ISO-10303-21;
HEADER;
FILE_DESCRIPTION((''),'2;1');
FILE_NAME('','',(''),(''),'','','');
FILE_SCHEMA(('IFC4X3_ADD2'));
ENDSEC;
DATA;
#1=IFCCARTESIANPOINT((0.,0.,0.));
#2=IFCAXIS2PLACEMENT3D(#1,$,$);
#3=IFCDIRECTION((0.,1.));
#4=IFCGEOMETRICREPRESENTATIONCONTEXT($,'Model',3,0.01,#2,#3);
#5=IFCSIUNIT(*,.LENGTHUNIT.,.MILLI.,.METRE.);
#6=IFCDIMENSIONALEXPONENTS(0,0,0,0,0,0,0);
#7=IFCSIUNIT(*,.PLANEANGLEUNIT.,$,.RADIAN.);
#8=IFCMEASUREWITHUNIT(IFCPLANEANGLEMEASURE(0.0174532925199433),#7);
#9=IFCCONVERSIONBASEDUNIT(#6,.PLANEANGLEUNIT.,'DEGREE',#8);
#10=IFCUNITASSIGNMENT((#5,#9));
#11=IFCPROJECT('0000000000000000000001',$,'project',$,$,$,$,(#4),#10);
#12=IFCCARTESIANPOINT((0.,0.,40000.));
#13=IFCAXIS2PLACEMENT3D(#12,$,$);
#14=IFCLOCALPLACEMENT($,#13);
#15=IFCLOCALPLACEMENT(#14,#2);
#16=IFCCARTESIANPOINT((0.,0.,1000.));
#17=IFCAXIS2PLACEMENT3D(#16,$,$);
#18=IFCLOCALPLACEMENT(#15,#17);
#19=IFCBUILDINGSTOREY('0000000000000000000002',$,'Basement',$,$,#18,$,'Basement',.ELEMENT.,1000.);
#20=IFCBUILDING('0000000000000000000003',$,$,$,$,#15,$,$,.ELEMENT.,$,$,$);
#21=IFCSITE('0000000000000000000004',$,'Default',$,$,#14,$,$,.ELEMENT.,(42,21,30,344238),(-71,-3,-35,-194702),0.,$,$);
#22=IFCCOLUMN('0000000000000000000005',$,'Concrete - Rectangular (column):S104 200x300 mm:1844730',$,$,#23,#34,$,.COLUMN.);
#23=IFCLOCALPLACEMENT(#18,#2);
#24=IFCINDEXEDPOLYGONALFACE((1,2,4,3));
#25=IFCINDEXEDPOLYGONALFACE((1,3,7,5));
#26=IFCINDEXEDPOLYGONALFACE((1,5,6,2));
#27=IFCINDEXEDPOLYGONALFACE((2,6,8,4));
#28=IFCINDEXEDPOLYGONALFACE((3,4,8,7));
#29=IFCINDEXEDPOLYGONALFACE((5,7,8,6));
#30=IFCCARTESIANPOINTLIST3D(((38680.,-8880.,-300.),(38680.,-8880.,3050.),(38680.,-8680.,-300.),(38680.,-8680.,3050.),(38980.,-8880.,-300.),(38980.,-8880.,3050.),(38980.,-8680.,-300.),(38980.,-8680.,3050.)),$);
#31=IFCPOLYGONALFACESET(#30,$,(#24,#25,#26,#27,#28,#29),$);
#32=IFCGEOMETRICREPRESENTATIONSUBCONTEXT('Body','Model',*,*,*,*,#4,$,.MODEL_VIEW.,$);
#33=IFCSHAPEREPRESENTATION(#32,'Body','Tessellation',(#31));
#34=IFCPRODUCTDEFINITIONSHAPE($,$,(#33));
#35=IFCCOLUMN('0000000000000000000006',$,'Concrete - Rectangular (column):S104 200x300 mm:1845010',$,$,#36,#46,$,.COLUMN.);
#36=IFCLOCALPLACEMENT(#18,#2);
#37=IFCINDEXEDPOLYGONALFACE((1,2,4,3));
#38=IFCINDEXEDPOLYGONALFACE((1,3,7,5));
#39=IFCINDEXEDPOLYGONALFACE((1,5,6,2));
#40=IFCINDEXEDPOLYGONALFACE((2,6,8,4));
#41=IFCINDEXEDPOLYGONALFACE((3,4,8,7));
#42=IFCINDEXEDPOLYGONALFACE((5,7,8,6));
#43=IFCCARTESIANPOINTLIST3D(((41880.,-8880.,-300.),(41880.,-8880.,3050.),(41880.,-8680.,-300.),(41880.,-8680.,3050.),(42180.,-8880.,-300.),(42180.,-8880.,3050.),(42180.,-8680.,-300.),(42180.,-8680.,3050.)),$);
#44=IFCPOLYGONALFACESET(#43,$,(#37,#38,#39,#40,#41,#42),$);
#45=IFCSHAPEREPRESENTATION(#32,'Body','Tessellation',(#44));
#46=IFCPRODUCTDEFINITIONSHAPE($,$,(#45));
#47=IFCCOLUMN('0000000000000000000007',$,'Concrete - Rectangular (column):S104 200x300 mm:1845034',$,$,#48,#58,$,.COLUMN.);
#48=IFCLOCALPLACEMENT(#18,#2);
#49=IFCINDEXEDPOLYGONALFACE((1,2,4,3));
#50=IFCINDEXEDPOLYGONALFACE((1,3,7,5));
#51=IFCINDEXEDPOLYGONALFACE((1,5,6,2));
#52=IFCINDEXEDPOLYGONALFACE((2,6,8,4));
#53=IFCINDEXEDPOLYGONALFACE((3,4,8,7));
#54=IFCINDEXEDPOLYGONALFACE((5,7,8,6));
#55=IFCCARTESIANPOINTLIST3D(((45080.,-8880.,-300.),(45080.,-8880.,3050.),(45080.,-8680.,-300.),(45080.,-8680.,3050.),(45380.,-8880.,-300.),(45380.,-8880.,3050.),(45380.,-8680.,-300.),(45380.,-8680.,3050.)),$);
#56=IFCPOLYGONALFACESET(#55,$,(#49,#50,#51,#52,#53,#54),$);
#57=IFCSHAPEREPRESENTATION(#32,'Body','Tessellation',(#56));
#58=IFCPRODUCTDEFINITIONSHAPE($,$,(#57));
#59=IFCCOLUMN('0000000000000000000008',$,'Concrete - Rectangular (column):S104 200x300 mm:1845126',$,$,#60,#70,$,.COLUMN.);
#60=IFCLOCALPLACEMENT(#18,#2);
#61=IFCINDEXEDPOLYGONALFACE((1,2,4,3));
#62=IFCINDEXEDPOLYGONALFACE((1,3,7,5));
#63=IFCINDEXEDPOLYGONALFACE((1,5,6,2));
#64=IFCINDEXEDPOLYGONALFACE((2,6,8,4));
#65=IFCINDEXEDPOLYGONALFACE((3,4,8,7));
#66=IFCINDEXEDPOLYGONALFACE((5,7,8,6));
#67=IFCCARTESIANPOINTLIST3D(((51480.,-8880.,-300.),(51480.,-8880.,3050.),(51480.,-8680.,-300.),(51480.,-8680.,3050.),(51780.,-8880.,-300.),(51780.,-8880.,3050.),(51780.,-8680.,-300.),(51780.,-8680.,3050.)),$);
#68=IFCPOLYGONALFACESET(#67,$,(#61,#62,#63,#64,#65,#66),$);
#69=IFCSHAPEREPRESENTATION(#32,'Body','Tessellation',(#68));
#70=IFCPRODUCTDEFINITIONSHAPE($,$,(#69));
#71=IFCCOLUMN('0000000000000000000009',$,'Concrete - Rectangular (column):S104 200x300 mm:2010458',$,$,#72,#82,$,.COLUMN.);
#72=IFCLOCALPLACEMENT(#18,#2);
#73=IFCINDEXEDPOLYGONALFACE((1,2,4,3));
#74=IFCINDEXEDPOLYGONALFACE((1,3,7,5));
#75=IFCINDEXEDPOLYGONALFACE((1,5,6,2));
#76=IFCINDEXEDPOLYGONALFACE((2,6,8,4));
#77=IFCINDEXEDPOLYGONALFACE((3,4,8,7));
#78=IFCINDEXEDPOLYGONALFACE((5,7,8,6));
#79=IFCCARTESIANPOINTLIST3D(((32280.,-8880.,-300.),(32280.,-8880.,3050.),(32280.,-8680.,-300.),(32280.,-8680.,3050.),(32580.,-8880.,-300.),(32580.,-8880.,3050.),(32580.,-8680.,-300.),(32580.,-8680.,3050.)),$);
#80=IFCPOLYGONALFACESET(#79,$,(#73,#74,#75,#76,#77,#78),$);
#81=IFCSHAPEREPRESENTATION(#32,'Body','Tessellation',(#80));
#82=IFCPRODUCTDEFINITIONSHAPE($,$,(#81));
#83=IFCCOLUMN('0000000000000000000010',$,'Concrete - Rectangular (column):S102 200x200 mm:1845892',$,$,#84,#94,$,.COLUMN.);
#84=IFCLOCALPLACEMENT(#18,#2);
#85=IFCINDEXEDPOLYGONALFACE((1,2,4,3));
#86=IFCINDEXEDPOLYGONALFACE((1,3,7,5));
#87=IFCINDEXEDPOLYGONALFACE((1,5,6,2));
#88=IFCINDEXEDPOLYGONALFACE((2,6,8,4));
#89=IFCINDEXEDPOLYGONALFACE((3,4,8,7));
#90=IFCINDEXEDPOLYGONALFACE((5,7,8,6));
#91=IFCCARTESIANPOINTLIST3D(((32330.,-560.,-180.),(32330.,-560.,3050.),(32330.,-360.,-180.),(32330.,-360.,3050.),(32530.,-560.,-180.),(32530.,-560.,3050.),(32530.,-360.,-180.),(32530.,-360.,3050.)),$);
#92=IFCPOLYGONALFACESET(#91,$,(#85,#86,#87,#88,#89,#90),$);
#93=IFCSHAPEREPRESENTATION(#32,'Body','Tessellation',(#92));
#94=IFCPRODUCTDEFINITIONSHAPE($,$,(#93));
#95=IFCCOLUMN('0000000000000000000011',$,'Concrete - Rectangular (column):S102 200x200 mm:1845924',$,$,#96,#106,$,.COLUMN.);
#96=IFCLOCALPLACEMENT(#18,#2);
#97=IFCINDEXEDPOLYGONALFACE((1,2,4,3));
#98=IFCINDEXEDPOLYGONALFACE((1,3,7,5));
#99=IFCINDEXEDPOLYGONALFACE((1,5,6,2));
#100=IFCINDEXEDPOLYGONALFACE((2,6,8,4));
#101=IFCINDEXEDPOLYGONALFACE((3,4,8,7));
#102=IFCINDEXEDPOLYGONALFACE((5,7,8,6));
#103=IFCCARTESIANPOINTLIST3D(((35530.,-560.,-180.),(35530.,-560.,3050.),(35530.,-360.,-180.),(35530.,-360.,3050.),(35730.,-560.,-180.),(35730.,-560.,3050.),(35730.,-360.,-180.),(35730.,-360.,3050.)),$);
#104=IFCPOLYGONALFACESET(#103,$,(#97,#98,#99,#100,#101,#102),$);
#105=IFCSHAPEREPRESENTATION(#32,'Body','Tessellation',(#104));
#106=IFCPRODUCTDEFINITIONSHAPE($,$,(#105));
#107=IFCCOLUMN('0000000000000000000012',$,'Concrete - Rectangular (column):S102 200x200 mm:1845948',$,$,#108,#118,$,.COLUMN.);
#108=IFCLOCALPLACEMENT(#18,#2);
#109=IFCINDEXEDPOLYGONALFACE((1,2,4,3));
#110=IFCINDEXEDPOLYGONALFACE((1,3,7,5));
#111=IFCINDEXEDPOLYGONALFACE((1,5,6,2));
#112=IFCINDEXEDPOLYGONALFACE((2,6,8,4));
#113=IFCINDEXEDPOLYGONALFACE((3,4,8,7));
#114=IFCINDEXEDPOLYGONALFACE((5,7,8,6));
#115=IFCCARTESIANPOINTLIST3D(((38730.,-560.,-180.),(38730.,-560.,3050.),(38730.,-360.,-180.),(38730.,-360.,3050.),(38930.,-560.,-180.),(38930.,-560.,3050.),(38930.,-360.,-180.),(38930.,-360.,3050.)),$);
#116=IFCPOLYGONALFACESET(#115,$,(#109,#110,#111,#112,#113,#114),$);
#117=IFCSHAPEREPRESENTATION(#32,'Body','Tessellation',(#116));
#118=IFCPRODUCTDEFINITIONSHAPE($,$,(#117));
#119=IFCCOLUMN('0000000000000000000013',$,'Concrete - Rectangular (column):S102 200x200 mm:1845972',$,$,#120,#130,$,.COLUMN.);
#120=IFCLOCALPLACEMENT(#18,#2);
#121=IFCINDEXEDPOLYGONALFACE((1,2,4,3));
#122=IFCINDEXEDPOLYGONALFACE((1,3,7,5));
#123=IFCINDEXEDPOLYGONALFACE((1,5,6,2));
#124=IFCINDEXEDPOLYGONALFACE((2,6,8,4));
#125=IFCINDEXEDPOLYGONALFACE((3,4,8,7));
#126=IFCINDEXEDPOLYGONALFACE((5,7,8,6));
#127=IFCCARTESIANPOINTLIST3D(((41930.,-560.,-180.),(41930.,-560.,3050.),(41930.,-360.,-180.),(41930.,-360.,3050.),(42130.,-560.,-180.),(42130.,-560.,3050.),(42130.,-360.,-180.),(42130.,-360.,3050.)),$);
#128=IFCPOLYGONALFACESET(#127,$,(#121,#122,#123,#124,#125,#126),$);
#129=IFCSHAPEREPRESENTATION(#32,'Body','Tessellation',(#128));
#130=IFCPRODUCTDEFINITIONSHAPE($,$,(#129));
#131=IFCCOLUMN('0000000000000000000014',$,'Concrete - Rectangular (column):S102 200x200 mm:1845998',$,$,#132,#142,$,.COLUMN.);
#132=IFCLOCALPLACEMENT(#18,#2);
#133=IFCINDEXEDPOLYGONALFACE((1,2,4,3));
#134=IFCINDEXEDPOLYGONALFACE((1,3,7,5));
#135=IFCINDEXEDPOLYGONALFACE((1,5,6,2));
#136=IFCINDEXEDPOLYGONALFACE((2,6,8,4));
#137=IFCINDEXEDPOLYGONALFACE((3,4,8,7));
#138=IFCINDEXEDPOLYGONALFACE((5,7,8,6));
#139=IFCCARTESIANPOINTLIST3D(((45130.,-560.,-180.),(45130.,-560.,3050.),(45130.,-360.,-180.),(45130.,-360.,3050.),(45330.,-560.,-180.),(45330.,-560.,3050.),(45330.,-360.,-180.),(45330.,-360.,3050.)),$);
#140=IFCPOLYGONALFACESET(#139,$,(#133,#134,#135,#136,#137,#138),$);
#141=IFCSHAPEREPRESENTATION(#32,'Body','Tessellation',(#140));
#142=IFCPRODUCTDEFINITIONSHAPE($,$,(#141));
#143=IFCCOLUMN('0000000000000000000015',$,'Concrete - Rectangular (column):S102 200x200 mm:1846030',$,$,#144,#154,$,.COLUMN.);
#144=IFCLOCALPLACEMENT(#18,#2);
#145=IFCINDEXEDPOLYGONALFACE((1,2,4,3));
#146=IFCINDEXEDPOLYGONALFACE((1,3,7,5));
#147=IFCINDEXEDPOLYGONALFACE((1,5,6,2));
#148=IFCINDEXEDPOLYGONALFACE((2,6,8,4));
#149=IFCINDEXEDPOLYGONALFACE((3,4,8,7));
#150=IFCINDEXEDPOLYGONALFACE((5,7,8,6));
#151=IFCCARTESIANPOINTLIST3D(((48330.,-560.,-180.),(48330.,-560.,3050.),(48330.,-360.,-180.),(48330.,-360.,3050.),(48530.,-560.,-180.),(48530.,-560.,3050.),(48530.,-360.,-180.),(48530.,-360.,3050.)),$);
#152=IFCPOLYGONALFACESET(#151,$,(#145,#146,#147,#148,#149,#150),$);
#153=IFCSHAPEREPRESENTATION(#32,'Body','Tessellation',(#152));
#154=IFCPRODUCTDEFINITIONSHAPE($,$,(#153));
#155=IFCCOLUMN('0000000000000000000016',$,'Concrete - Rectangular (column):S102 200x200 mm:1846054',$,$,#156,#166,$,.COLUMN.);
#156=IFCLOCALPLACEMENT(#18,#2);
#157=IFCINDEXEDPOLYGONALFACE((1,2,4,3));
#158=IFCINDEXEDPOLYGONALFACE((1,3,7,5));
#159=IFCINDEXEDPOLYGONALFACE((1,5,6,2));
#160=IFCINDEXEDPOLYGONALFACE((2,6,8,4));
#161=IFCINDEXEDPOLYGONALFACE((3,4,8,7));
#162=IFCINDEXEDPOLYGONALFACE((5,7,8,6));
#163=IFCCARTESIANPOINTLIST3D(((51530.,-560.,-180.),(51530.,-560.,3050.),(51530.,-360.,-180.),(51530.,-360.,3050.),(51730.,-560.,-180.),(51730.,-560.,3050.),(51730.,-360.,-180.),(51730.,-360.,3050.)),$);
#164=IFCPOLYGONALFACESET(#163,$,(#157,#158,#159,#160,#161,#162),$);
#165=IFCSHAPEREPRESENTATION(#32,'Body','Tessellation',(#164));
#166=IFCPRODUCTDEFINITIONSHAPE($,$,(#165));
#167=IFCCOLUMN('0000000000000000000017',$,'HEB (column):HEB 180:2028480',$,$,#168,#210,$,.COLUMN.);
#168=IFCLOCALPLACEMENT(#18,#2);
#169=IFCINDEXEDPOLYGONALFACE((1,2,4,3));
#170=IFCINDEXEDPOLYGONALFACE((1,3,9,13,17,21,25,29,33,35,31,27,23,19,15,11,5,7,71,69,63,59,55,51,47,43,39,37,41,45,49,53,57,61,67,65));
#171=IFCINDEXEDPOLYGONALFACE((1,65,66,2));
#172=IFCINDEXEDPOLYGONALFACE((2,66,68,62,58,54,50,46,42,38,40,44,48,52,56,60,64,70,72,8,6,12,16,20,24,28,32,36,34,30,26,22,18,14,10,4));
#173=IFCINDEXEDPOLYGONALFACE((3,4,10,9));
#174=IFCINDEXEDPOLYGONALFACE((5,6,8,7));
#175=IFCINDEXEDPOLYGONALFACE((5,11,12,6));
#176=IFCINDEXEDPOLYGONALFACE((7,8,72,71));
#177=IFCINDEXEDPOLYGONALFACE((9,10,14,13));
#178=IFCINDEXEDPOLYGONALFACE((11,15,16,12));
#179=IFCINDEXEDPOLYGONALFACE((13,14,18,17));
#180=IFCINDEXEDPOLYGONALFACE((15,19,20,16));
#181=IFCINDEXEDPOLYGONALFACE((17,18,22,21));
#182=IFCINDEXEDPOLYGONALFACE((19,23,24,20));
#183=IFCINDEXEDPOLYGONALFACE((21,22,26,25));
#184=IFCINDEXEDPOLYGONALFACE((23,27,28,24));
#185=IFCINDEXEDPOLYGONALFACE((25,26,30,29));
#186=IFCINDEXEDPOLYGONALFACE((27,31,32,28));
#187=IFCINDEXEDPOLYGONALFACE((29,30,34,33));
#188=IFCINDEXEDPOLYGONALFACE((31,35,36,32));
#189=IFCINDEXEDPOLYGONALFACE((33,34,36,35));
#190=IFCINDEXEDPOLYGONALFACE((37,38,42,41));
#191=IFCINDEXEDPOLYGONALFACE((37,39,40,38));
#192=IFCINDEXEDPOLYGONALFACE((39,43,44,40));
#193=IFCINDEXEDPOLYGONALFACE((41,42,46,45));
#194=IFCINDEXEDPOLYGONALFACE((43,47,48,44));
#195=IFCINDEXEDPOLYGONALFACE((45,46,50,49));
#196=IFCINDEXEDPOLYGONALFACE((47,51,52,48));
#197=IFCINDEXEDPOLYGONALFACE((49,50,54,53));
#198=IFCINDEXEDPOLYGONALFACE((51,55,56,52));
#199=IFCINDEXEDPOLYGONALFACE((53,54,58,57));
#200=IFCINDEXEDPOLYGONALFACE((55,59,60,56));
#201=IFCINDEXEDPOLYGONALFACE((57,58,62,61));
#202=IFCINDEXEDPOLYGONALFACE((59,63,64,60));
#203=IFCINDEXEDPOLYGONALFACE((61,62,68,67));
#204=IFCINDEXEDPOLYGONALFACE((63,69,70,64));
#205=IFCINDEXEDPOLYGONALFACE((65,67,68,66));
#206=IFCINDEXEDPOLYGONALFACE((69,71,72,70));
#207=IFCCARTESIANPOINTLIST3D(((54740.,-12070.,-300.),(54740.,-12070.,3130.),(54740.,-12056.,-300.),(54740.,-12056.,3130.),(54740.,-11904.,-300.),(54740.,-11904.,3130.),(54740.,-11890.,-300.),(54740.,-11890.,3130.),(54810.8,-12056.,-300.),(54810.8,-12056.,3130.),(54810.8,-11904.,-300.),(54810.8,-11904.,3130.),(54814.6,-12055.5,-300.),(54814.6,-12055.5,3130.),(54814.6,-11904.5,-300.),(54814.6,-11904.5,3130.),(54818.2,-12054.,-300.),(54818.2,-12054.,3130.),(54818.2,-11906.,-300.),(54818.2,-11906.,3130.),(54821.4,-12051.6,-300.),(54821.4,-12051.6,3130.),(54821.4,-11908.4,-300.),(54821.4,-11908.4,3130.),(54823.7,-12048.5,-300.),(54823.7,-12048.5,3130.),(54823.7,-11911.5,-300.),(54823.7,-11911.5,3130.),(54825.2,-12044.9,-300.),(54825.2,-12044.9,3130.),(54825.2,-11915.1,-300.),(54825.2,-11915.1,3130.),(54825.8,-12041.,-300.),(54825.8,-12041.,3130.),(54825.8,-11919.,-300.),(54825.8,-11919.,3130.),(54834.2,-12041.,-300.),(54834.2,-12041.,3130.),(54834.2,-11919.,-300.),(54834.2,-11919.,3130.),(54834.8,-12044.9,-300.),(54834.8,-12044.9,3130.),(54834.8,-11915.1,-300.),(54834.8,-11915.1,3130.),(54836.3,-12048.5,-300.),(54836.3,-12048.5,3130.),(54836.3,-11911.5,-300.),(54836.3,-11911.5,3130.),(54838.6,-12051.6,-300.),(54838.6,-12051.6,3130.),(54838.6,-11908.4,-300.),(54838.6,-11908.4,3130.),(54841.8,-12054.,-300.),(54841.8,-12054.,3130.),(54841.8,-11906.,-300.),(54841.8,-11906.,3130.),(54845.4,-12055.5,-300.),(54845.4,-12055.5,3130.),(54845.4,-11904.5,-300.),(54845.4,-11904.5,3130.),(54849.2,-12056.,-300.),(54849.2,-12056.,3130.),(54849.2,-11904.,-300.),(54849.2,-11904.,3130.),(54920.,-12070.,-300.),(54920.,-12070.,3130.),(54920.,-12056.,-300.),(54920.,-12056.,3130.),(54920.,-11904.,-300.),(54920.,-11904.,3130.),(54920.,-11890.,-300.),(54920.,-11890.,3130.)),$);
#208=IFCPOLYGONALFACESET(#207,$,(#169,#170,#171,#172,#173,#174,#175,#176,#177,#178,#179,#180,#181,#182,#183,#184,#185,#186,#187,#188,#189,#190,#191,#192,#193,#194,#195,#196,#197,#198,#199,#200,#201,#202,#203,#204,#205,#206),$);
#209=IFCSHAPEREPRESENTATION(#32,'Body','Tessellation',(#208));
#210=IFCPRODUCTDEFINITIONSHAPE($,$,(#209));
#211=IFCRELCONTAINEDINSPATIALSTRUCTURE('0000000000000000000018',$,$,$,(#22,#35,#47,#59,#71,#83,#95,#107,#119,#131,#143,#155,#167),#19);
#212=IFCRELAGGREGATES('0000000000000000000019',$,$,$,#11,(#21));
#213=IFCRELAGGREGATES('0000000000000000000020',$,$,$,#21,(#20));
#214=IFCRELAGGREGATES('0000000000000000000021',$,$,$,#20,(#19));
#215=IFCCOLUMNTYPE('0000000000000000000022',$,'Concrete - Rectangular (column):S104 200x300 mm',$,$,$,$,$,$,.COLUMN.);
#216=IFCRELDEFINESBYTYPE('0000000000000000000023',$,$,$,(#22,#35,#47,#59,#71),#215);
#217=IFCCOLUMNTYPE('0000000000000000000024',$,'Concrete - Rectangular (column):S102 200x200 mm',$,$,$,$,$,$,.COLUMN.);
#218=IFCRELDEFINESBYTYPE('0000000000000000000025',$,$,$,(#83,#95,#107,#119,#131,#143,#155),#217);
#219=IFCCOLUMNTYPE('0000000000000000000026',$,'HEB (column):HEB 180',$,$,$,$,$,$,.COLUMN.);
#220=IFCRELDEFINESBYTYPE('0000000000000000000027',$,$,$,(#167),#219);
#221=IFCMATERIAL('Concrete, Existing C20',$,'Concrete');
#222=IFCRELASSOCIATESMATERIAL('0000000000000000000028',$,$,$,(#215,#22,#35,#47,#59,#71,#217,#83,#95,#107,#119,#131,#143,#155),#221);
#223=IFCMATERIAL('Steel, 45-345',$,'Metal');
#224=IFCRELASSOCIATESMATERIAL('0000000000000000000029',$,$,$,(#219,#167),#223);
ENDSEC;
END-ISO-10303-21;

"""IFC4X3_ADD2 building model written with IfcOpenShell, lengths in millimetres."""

from ifc_helpers import new_model, entity, si_unit, converted_unit, direction, frame, frame_2d, origin, origin_2d_with_axis, place, context, subcontext, project, spatial, rectangle, i_section, extrude, source, transform, mapped, material, material_profile, profile_set, profile_usage, type_object, type_shapes, element, save


model = new_model("IFC4X3_ADD2")

# Units and contexts
model_context = context("Model", 3, precision=0.01, world=origin(), true_north=direction((0.0, 1.0)))
body_context = subcontext(model_context, "Body", "Model", "MODEL_VIEW")
ifc_project = project(units=[si_unit("LENGTHUNIT", "METRE", prefix="MILLI"), converted_unit("PLANEANGLEUNIT", "DEGREE", entity("IfcPlaneAngleMeasure", 0.0174532925199433), si_unit("PLANEANGLEUNIT", "RADIAN"), dimensions=[0, 0, 0, 0, 0, 0, 0])], contexts=[model_context])

# Site, building, storey
site_placement = place(None, frame((0.0, 0.0, 40000.0)))
site = spatial("IfcSite", under=ifc_project, at=site_placement, Name="Default", CompositionType="ELEMENT", RefLatitude=(42, 21, 30, 344238), RefLongitude=(-71, -3, -35, -194702), RefElevation=0.0)
building_placement = place(site_placement, origin())
building = spatial("IfcBuilding", under=site, at=building_placement, CompositionType="ELEMENT")
storey_placement = place(building_placement, frame((0.0, 0.0, 1000.0)))
storey = spatial("IfcBuildingStorey", under=building, at=storey_placement, Name="Basement", LongName="Basement", CompositionType="ELEMENT", Elevation=1000.0)

# Columns
ifc_material_1 = material(Name="Concrete, Existing C20", Category="Concrete")
ifc_material_profile_1 = material_profile(ifc_material_1, rectangle(XDim=200.0, YDim=300.0, at=frame_2d((0.0, 0.0), x_axis=(1.0, 0.0))), Name="S104 200x300 mm")
ifc_profile_set_1 = profile_set([ifc_material_profile_1], Name="S104 200x300 mm")
ifc_profile_usage_1 = profile_usage(ifc_profile_set_1)
column_type_1 = type_object("IfcColumnType", Name="Concrete - Rectangular (column):S104 200x300 mm", PredefinedType="COLUMN", material=ifc_profile_set_1)
shared_shape_1 = source(origin(), body_context, "Body", "SweptSolid", [
    extrude(rectangle(XDim=200.0, YDim=300.0, at=origin_2d_with_axis()), frame((0.0, 0.0, 700.0), z_axis=(0.0, 0.0, 1.0), x_axis=(-1.0, 0.0, 0.0)), (0.0, 0.0, 1.0), 3350.0),
])
type_shapes(column_type_1, [shared_shape_1])
for number, where, z_axis, x_axis, name in (
    (1, (38830.0, -8780.0, -1000.0), (0.0, 0.0, 1.0), (0.0, -1.0, 0.0), "Concrete - Rectangular (column):S104 200x300 mm:1844730"),
    (2, (42030.0, -8780.0, -1000.0), (0.0, 0.0, 1.0), (0.0, -1.0, 0.0), "Concrete - Rectangular (column):S104 200x300 mm:1845010"),
    (3, (45230.0, -8780.0, -1000.0), (0.0, 0.0, 1.0), (0.0, -1.0, 0.0), "Concrete - Rectangular (column):S104 200x300 mm:1845034"),
    (4, (51630.0, -8780.0, -1000.0), (0.0, 0.0, 1.0), (0.0, -1.0, 0.0), "Concrete - Rectangular (column):S104 200x300 mm:1845126"),
    (5, (32430.0, -8780.0, -1000.0), (0.0, 0.0, 1.0), (0.0, -1.0, 0.0), "Concrete - Rectangular (column):S104 200x300 mm:2010458"),
):
    element("IfcColumn", number, at=place(storey_placement, frame(where, z_axis=z_axis, x_axis=x_axis)), inside=storey, type_object=column_type_1, material=ifc_profile_usage_1, Name=name, PredefinedType="COLUMN", context=body_context, shape_type="MappedRepresentation", body=[
        mapped(shared_shape_1, transform((0.0, 0.0, 0.0), scale=1.0)),
    ])
ifc_material_profile_2 = material_profile(ifc_material_1, rectangle(XDim=200.0, YDim=200.0, at=frame_2d((0.0, 0.0), x_axis=(1.0, 0.0))), Name="S102 200x200 mm")
ifc_profile_set_2 = profile_set([ifc_material_profile_2], Name="S102 200x200 mm")
ifc_profile_usage_2 = profile_usage(ifc_profile_set_2)
column_type_2 = type_object("IfcColumnType", Name="Concrete - Rectangular (column):S102 200x200 mm", PredefinedType="COLUMN", material=ifc_profile_set_2)
shared_shape_2 = source(origin(), body_context, "Body", "SweptSolid", [
    extrude(rectangle(XDim=200.0, YDim=200.0, at=origin_2d_with_axis()), frame((0.0, 0.0, 820.0), z_axis=(0.0, 0.0, 1.0), x_axis=(-1.0, 0.0, 0.0)), (0.0, 0.0, 1.0), 3230.0),
])
type_shapes(column_type_2, [shared_shape_2])
for number, where, z_axis, x_axis, name in (
    (6, (32430.0, -460.0, -1000.0), (0.0, 0.0, 1.0), (0.0, -1.0, 0.0), "Concrete - Rectangular (column):S102 200x200 mm:1845892"),
    (7, (35630.0, -460.0, -1000.0), (0.0, 0.0, 1.0), (0.0, -1.0, 0.0), "Concrete - Rectangular (column):S102 200x200 mm:1845924"),
    (8, (38830.0, -460.0, -1000.0), (0.0, 0.0, 1.0), (0.0, -1.0, 0.0), "Concrete - Rectangular (column):S102 200x200 mm:1845948"),
    (9, (42030.0, -460.0, -1000.0), (0.0, 0.0, 1.0), (0.0, -1.0, 0.0), "Concrete - Rectangular (column):S102 200x200 mm:1845972"),
    (10, (45230.0, -460.0, -1000.0), (0.0, 0.0, 1.0), (0.0, -1.0, 0.0), "Concrete - Rectangular (column):S102 200x200 mm:1845998"),
    (11, (48430.0, -460.0, -1000.0), (0.0, 0.0, 1.0), (0.0, -1.0, 0.0), "Concrete - Rectangular (column):S102 200x200 mm:1846030"),
    (12, (51630.0, -460.0, -1000.0), (0.0, 0.0, 1.0), (0.0, -1.0, 0.0), "Concrete - Rectangular (column):S102 200x200 mm:1846054"),
):
    element("IfcColumn", number, at=place(storey_placement, frame(where, z_axis=z_axis, x_axis=x_axis)), inside=storey, type_object=column_type_2, material=ifc_profile_usage_2, Name=name, PredefinedType="COLUMN", context=body_context, shape_type="MappedRepresentation", body=[
        mapped(shared_shape_2, transform((0.0, 0.0, 0.0), scale=1.0)),
    ])
ifc_material_2 = material(Name="Steel, 45-345", Category="Metal")
ifc_material_profile_3 = material_profile(ifc_material_2, i_section(OverallWidth=180.0, OverallDepth=180.0, WebThickness=8.5, FlangeThickness=14.0, FilletRadius=15.0, at=origin_2d_with_axis()), Name="HEB 180")
ifc_profile_set_3 = profile_set([ifc_material_profile_3], Name="HEB 180")
ifc_profile_usage_3 = profile_usage(ifc_profile_set_3)
column_type_3 = type_object("IfcColumnType", Name="HEB (column):HEB 180", PredefinedType="COLUMN", material=ifc_profile_set_3)
shared_shape_3 = source(origin(), body_context, "Body", "SweptSolid", [
    extrude(i_section(OverallWidth=180.0, OverallDepth=180.0, WebThickness=8.5, FlangeThickness=14.0, FilletRadius=15.0, at=origin_2d_with_axis()), frame((0.0, 0.0, 700.0), z_axis=(0.0, 0.0, 1.0), x_axis=(-1.0, 0.0, 0.0)), (0.0, 0.0, 1.0), 3430.0),
])
type_shapes(column_type_3, [shared_shape_3])
column_placement = place(storey_placement, frame((54830.0, -11980.0, -1000.0)))
element("IfcColumn", 13, at=column_placement, inside=storey, type_object=column_type_3, material=ifc_profile_usage_3, Name="HEB (column):HEB 180:2028480", PredefinedType="COLUMN", context=body_context, shape_type="MappedRepresentation", body=[
    mapped(shared_shape_3, transform((0.0, 0.0, 0.0), scale=1.0)),
])

save(model, "model.ifc")
